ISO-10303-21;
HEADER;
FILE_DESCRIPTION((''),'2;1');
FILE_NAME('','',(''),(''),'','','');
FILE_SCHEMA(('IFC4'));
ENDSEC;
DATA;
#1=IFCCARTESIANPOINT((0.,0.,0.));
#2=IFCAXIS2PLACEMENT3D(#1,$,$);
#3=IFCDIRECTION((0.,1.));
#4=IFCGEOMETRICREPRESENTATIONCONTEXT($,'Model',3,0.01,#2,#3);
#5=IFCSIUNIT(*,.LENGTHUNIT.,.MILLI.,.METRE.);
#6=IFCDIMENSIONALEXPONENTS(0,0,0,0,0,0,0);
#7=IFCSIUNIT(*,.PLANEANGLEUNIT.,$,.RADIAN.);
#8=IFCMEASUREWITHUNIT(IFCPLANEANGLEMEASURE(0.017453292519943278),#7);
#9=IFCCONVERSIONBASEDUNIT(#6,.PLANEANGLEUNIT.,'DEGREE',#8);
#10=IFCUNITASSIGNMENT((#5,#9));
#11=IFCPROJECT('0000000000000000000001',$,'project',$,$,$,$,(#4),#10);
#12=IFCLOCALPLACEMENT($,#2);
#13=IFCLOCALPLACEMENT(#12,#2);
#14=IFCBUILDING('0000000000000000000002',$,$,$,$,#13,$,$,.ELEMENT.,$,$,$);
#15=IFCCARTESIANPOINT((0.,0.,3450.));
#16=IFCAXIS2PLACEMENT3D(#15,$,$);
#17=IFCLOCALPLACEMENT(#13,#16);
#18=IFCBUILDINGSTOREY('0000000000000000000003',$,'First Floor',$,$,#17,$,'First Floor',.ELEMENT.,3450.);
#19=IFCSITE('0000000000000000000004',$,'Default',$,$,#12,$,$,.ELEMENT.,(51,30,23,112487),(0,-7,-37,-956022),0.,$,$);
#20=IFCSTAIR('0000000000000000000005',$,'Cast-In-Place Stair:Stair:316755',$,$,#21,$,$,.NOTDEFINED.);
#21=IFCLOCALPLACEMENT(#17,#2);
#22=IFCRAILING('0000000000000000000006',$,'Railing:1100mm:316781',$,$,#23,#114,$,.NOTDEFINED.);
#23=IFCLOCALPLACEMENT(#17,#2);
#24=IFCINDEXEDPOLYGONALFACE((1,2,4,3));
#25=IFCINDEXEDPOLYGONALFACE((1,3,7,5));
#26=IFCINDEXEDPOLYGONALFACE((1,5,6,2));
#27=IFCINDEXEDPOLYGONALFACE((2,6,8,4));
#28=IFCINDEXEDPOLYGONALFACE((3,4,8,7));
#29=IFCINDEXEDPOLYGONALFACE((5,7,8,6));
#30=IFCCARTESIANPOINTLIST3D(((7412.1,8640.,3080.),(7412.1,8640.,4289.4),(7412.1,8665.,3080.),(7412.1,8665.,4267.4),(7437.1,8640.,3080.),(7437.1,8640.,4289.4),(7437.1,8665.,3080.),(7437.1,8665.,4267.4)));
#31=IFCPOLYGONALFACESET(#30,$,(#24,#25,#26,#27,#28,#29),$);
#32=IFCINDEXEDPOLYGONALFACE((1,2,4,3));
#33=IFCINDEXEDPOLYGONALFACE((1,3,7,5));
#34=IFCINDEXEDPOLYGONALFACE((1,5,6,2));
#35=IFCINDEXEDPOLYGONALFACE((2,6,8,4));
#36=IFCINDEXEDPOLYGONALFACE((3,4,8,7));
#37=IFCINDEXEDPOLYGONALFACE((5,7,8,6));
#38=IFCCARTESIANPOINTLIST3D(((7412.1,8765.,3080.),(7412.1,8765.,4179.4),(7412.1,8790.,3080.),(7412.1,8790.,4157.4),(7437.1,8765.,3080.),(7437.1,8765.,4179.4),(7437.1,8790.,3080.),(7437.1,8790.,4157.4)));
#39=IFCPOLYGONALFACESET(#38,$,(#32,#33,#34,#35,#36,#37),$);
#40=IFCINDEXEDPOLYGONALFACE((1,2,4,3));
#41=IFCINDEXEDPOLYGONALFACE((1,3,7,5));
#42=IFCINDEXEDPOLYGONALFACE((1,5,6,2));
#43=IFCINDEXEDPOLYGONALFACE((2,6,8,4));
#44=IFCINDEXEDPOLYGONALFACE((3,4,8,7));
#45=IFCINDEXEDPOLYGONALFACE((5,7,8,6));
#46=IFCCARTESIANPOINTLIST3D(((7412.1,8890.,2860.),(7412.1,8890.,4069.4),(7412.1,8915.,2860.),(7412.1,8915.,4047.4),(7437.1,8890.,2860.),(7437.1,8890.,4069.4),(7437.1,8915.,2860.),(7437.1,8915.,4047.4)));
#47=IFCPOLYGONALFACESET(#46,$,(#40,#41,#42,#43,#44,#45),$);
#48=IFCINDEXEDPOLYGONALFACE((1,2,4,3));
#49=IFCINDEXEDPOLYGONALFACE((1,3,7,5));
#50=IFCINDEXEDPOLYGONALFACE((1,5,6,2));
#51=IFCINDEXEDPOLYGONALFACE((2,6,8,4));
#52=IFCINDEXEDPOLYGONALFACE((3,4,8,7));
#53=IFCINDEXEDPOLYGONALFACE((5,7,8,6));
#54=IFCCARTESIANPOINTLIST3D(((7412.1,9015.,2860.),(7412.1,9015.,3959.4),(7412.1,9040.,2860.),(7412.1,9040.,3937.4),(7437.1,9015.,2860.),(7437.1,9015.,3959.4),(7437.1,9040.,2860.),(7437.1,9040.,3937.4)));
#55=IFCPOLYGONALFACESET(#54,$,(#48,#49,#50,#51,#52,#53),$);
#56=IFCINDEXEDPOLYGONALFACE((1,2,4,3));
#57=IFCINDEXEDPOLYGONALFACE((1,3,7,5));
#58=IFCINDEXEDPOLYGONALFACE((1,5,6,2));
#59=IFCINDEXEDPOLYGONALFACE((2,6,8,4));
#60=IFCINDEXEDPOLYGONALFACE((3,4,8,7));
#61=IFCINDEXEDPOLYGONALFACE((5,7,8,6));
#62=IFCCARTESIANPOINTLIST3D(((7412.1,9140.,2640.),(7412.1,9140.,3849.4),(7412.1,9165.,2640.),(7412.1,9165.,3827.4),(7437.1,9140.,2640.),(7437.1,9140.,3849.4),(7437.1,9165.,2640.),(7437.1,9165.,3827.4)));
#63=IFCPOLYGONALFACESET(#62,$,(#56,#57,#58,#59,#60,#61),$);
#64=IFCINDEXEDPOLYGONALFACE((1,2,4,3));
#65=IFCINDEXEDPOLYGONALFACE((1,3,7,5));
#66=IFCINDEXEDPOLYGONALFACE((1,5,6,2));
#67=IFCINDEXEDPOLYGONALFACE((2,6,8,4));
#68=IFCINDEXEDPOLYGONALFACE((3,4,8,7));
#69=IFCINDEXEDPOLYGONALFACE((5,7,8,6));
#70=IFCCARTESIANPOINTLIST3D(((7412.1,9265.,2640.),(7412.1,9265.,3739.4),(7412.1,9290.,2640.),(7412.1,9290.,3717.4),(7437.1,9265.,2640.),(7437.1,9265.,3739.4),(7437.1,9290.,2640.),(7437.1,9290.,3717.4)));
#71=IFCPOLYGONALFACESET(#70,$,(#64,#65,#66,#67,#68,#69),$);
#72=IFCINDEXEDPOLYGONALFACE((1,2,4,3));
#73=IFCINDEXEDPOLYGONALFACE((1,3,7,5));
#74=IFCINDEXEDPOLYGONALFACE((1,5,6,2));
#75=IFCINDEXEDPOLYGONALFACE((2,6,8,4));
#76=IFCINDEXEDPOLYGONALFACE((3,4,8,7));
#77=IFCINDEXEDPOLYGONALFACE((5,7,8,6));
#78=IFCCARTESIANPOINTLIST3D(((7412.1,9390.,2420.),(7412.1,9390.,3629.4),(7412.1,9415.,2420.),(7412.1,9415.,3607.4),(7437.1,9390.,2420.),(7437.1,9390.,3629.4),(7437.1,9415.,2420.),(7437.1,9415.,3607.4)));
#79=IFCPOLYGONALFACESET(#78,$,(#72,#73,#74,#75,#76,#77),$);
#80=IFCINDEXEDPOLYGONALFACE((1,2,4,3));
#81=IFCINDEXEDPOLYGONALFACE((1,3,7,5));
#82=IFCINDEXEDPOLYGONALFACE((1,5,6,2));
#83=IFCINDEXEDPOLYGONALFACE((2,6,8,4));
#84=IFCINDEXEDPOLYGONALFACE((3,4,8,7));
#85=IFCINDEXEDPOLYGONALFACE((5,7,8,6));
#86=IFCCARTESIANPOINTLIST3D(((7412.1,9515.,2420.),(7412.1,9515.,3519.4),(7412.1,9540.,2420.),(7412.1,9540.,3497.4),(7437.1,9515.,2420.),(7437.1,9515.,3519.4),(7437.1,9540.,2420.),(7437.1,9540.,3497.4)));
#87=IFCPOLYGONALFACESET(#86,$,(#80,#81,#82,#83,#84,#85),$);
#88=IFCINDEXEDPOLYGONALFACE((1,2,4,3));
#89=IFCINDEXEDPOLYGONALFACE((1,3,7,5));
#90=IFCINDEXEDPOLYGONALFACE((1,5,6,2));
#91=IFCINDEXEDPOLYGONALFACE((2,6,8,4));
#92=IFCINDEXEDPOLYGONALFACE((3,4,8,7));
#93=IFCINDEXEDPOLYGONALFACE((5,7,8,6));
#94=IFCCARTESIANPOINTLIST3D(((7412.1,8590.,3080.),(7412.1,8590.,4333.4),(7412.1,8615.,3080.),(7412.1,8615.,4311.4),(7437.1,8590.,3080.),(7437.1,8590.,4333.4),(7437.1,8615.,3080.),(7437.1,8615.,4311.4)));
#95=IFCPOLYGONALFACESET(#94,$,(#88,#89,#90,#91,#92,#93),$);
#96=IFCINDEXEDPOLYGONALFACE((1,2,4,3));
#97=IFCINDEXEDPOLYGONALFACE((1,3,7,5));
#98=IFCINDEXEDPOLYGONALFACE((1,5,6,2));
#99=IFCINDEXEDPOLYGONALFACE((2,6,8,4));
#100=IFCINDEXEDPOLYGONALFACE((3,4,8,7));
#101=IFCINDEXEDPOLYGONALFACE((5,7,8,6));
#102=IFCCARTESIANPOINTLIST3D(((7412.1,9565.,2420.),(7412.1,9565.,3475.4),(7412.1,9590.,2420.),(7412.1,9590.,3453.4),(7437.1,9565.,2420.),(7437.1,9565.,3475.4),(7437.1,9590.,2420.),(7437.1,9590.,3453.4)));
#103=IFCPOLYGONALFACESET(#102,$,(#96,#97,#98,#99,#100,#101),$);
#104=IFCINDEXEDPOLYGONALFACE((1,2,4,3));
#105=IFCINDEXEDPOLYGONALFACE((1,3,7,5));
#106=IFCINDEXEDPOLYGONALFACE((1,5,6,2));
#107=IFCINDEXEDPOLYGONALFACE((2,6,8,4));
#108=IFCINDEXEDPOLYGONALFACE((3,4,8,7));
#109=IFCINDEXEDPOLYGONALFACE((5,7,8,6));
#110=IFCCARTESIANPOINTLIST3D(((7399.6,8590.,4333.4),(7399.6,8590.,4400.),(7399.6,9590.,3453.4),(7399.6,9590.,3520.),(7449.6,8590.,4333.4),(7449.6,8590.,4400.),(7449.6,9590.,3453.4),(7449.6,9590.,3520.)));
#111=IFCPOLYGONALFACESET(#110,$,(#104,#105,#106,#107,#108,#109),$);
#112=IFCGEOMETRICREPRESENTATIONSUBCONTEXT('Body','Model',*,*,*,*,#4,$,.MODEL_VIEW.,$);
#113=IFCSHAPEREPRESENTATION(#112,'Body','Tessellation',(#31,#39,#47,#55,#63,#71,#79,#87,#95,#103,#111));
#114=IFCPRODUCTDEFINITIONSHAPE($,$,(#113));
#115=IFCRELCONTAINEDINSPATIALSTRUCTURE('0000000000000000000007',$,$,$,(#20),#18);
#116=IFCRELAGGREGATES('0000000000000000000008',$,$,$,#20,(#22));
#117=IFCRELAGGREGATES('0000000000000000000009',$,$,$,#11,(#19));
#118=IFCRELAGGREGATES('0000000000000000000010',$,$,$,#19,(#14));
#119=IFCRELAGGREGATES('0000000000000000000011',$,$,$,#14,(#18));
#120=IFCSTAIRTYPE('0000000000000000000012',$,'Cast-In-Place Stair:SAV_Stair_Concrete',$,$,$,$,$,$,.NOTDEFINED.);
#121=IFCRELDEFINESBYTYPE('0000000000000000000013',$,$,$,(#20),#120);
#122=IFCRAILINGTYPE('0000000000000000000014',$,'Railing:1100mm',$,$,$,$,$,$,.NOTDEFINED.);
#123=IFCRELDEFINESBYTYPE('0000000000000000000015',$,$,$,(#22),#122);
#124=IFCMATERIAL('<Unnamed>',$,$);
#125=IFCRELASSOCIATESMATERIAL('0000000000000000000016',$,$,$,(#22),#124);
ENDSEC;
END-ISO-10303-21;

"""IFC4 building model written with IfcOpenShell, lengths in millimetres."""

from ifc_helpers import new_model, entity, si_unit, converted_unit, direction, frame, origin, place, context, subcontext, project, spatial, polyline, outline, extrude, material, type_object, element, aggregate, save


model = new_model("IFC4")

# Units and contexts
model_context = context("Model", 3, precision=0.01, world=origin(), true_north=direction((0.0, 1.0)))
body_context = subcontext(model_context, "Body", "Model", "MODEL_VIEW")
ifc_project = project(units=[si_unit("LENGTHUNIT", "METRE", prefix="MILLI"), converted_unit("PLANEANGLEUNIT", "DEGREE", entity("IfcPlaneAngleMeasure", 0.017453292519943278), si_unit("PLANEANGLEUNIT", "RADIAN"), dimensions=[0, 0, 0, 0, 0, 0, 0])], contexts=[model_context])

# Site, building, storey
site_placement = place(None, origin())
site = spatial("IfcSite", under=ifc_project, at=site_placement, Name="Default", CompositionType="ELEMENT", RefLatitude=(51, 30, 23, 112487), RefLongitude=(0, -7, -37, -956022), RefElevation=0.0)
building_placement = place(site_placement, origin())
building = spatial("IfcBuilding", under=site, at=building_placement, CompositionType="ELEMENT")
storey_placement = place(building_placement, frame((0.0, 0.0, 3450.0)))
storey = spatial("IfcBuildingStorey", under=building, at=storey_placement, Name="First Floor", LongName="First Floor", CompositionType="ELEMENT", Elevation=3450.0)

# Shared definitions
ifc_material_1 = material(Name="<Unnamed>")

# Stair, railing
stair_type = type_object("IfcStairType", Name="Cast-In-Place Stair:SAV_Stair_Concrete", PredefinedType="NOTDEFINED")
stair_placement = place(storey_placement, origin())
stair = element("IfcStair", 1, at=stair_placement, inside=storey, type_object=stair_type, Name="Cast-In-Place Stair:Stair:316755", PredefinedType="NOTDEFINED")
railing_type_1 = type_object("IfcRailingType", Name="Railing:1100mm", PredefinedType="NOTDEFINED")
railing_1_placement = place(stair_placement, frame((7399.6, 8590.0, 2420.0)))
railing_1 = element("IfcRailing", 2, at=railing_1_placement, type_object=railing_type_1, material=ifc_material_1, Name="Railing:1100mm:316781", PredefinedType="NOTDEFINED", context=body_context, shape_type="SweptSolid", body=[
    extrude(outline(polyline([(-599.2, -12.5), (588.2, -12.5), (610.2, 12.5), (-599.2, 12.5), (-599.2, -12.5)])), frame((12.5, 62.5, 1259.2), z_axis=(1.0, 0.0, 0.0), x_axis=(0.0, 0.0, 1.0)), (0.0, 0.0, 1.0), 25.0),
    extrude(outline(polyline([(-544.2, -12.5), (533.2, -12.5), (555.2, 12.5), (-544.2, 12.5), (-544.2, -12.5)])), frame((12.5, 187.5, 1204.2), z_axis=(1.0, 0.0, 0.0), x_axis=(0.0, 0.0, 1.0)), (0.0, 0.0, 1.0), 25.0),
    extrude(outline(polyline([(-599.2, -12.5), (588.2, -12.5), (610.2, 12.5), (-599.2, 12.5), (-599.2, -12.5)])), frame((12.5, 312.5, 1039.2), z_axis=(1.0, 0.0, 0.0), x_axis=(0.0, 0.0, 1.0)), (0.0, 0.0, 1.0), 25.0),
    extrude(outline(polyline([(-544.2, -12.5), (533.2, -12.5), (555.2, 12.5), (-544.2, 12.5), (-544.2, -12.5)])), frame((12.5, 437.5, 984.2), z_axis=(1.0, 0.0, 0.0), x_axis=(0.0, 0.0, 1.0)), (0.0, 0.0, 1.0), 25.0),
    extrude(outline(polyline([(-599.2, -12.5), (588.2, -12.5), (610.2, 12.5), (-599.2, 12.5), (-599.2, -12.5)])), frame((12.5, 562.5, 819.2), z_axis=(1.0, 0.0, 0.0), x_axis=(0.0, 0.0, 1.0)), (0.0, 0.0, 1.0), 25.0),
    extrude(outline(polyline([(-544.2, -12.5), (533.2, -12.5), (555.2, 12.5), (-544.2, 12.5), (-544.2, -12.5)])), frame((12.5, 687.5, 764.2), z_axis=(1.0, 0.0, 0.0), x_axis=(0.0, 0.0, 1.0)), (0.0, 0.0, 1.0), 25.0),
    extrude(outline(polyline([(-599.2, -12.5), (588.2, -12.5), (610.2, 12.5), (-599.2, 12.5), (-599.2, -12.5)])), frame((12.5, 812.5, 599.2), z_axis=(1.0, 0.0, 0.0), x_axis=(0.0, 0.0, 1.0)), (0.0, 0.0, 1.0), 25.0),
    extrude(outline(polyline([(-544.2, -12.5), (533.2, -12.5), (555.2, 12.5), (-544.2, 12.5), (-544.2, -12.5)])), frame((12.5, 937.5, 544.2), z_axis=(1.0, 0.0, 0.0), x_axis=(0.0, 0.0, 1.0)), (0.0, 0.0, 1.0), 25.0),
    extrude(outline(polyline([(-621.2, -12.5), (610.2, -12.5), (632.2, 12.5), (-621.2, 12.5), (-621.2, -12.5)])), frame((12.5, 12.5, 1281.2), z_axis=(1.0, 0.0, 0.0), x_axis=(0.0, 0.0, 1.0)), (0.0, 0.0, 1.0), 25.0),
    extrude(outline(polyline([(-522.2, -12.5), (511.2, -12.5), (533.2, 12.5), (-522.2, 12.5), (-522.2, -12.5)])), frame((12.5, 987.5, 522.2), z_axis=(1.0, 0.0, 0.0), x_axis=(0.0, 0.0, 1.0)), (0.0, 0.0, 1.0), 25.0),
    extrude(outline(polyline([(-644.0, -25.0), (688.0, -25.0), (644.0, 25.0), (-688.0, 25.0), (-644.0, -25.0)])), frame((0.0, 500.0, 1506.7), z_axis=(1.0, 0.0, 0.0), x_axis=(0.0, -0.750714, 0.660628)), (0.0, 0.0, 1.0), 50.0),
])
aggregate(stair, [railing_1])

save(model, "model.ifc")
